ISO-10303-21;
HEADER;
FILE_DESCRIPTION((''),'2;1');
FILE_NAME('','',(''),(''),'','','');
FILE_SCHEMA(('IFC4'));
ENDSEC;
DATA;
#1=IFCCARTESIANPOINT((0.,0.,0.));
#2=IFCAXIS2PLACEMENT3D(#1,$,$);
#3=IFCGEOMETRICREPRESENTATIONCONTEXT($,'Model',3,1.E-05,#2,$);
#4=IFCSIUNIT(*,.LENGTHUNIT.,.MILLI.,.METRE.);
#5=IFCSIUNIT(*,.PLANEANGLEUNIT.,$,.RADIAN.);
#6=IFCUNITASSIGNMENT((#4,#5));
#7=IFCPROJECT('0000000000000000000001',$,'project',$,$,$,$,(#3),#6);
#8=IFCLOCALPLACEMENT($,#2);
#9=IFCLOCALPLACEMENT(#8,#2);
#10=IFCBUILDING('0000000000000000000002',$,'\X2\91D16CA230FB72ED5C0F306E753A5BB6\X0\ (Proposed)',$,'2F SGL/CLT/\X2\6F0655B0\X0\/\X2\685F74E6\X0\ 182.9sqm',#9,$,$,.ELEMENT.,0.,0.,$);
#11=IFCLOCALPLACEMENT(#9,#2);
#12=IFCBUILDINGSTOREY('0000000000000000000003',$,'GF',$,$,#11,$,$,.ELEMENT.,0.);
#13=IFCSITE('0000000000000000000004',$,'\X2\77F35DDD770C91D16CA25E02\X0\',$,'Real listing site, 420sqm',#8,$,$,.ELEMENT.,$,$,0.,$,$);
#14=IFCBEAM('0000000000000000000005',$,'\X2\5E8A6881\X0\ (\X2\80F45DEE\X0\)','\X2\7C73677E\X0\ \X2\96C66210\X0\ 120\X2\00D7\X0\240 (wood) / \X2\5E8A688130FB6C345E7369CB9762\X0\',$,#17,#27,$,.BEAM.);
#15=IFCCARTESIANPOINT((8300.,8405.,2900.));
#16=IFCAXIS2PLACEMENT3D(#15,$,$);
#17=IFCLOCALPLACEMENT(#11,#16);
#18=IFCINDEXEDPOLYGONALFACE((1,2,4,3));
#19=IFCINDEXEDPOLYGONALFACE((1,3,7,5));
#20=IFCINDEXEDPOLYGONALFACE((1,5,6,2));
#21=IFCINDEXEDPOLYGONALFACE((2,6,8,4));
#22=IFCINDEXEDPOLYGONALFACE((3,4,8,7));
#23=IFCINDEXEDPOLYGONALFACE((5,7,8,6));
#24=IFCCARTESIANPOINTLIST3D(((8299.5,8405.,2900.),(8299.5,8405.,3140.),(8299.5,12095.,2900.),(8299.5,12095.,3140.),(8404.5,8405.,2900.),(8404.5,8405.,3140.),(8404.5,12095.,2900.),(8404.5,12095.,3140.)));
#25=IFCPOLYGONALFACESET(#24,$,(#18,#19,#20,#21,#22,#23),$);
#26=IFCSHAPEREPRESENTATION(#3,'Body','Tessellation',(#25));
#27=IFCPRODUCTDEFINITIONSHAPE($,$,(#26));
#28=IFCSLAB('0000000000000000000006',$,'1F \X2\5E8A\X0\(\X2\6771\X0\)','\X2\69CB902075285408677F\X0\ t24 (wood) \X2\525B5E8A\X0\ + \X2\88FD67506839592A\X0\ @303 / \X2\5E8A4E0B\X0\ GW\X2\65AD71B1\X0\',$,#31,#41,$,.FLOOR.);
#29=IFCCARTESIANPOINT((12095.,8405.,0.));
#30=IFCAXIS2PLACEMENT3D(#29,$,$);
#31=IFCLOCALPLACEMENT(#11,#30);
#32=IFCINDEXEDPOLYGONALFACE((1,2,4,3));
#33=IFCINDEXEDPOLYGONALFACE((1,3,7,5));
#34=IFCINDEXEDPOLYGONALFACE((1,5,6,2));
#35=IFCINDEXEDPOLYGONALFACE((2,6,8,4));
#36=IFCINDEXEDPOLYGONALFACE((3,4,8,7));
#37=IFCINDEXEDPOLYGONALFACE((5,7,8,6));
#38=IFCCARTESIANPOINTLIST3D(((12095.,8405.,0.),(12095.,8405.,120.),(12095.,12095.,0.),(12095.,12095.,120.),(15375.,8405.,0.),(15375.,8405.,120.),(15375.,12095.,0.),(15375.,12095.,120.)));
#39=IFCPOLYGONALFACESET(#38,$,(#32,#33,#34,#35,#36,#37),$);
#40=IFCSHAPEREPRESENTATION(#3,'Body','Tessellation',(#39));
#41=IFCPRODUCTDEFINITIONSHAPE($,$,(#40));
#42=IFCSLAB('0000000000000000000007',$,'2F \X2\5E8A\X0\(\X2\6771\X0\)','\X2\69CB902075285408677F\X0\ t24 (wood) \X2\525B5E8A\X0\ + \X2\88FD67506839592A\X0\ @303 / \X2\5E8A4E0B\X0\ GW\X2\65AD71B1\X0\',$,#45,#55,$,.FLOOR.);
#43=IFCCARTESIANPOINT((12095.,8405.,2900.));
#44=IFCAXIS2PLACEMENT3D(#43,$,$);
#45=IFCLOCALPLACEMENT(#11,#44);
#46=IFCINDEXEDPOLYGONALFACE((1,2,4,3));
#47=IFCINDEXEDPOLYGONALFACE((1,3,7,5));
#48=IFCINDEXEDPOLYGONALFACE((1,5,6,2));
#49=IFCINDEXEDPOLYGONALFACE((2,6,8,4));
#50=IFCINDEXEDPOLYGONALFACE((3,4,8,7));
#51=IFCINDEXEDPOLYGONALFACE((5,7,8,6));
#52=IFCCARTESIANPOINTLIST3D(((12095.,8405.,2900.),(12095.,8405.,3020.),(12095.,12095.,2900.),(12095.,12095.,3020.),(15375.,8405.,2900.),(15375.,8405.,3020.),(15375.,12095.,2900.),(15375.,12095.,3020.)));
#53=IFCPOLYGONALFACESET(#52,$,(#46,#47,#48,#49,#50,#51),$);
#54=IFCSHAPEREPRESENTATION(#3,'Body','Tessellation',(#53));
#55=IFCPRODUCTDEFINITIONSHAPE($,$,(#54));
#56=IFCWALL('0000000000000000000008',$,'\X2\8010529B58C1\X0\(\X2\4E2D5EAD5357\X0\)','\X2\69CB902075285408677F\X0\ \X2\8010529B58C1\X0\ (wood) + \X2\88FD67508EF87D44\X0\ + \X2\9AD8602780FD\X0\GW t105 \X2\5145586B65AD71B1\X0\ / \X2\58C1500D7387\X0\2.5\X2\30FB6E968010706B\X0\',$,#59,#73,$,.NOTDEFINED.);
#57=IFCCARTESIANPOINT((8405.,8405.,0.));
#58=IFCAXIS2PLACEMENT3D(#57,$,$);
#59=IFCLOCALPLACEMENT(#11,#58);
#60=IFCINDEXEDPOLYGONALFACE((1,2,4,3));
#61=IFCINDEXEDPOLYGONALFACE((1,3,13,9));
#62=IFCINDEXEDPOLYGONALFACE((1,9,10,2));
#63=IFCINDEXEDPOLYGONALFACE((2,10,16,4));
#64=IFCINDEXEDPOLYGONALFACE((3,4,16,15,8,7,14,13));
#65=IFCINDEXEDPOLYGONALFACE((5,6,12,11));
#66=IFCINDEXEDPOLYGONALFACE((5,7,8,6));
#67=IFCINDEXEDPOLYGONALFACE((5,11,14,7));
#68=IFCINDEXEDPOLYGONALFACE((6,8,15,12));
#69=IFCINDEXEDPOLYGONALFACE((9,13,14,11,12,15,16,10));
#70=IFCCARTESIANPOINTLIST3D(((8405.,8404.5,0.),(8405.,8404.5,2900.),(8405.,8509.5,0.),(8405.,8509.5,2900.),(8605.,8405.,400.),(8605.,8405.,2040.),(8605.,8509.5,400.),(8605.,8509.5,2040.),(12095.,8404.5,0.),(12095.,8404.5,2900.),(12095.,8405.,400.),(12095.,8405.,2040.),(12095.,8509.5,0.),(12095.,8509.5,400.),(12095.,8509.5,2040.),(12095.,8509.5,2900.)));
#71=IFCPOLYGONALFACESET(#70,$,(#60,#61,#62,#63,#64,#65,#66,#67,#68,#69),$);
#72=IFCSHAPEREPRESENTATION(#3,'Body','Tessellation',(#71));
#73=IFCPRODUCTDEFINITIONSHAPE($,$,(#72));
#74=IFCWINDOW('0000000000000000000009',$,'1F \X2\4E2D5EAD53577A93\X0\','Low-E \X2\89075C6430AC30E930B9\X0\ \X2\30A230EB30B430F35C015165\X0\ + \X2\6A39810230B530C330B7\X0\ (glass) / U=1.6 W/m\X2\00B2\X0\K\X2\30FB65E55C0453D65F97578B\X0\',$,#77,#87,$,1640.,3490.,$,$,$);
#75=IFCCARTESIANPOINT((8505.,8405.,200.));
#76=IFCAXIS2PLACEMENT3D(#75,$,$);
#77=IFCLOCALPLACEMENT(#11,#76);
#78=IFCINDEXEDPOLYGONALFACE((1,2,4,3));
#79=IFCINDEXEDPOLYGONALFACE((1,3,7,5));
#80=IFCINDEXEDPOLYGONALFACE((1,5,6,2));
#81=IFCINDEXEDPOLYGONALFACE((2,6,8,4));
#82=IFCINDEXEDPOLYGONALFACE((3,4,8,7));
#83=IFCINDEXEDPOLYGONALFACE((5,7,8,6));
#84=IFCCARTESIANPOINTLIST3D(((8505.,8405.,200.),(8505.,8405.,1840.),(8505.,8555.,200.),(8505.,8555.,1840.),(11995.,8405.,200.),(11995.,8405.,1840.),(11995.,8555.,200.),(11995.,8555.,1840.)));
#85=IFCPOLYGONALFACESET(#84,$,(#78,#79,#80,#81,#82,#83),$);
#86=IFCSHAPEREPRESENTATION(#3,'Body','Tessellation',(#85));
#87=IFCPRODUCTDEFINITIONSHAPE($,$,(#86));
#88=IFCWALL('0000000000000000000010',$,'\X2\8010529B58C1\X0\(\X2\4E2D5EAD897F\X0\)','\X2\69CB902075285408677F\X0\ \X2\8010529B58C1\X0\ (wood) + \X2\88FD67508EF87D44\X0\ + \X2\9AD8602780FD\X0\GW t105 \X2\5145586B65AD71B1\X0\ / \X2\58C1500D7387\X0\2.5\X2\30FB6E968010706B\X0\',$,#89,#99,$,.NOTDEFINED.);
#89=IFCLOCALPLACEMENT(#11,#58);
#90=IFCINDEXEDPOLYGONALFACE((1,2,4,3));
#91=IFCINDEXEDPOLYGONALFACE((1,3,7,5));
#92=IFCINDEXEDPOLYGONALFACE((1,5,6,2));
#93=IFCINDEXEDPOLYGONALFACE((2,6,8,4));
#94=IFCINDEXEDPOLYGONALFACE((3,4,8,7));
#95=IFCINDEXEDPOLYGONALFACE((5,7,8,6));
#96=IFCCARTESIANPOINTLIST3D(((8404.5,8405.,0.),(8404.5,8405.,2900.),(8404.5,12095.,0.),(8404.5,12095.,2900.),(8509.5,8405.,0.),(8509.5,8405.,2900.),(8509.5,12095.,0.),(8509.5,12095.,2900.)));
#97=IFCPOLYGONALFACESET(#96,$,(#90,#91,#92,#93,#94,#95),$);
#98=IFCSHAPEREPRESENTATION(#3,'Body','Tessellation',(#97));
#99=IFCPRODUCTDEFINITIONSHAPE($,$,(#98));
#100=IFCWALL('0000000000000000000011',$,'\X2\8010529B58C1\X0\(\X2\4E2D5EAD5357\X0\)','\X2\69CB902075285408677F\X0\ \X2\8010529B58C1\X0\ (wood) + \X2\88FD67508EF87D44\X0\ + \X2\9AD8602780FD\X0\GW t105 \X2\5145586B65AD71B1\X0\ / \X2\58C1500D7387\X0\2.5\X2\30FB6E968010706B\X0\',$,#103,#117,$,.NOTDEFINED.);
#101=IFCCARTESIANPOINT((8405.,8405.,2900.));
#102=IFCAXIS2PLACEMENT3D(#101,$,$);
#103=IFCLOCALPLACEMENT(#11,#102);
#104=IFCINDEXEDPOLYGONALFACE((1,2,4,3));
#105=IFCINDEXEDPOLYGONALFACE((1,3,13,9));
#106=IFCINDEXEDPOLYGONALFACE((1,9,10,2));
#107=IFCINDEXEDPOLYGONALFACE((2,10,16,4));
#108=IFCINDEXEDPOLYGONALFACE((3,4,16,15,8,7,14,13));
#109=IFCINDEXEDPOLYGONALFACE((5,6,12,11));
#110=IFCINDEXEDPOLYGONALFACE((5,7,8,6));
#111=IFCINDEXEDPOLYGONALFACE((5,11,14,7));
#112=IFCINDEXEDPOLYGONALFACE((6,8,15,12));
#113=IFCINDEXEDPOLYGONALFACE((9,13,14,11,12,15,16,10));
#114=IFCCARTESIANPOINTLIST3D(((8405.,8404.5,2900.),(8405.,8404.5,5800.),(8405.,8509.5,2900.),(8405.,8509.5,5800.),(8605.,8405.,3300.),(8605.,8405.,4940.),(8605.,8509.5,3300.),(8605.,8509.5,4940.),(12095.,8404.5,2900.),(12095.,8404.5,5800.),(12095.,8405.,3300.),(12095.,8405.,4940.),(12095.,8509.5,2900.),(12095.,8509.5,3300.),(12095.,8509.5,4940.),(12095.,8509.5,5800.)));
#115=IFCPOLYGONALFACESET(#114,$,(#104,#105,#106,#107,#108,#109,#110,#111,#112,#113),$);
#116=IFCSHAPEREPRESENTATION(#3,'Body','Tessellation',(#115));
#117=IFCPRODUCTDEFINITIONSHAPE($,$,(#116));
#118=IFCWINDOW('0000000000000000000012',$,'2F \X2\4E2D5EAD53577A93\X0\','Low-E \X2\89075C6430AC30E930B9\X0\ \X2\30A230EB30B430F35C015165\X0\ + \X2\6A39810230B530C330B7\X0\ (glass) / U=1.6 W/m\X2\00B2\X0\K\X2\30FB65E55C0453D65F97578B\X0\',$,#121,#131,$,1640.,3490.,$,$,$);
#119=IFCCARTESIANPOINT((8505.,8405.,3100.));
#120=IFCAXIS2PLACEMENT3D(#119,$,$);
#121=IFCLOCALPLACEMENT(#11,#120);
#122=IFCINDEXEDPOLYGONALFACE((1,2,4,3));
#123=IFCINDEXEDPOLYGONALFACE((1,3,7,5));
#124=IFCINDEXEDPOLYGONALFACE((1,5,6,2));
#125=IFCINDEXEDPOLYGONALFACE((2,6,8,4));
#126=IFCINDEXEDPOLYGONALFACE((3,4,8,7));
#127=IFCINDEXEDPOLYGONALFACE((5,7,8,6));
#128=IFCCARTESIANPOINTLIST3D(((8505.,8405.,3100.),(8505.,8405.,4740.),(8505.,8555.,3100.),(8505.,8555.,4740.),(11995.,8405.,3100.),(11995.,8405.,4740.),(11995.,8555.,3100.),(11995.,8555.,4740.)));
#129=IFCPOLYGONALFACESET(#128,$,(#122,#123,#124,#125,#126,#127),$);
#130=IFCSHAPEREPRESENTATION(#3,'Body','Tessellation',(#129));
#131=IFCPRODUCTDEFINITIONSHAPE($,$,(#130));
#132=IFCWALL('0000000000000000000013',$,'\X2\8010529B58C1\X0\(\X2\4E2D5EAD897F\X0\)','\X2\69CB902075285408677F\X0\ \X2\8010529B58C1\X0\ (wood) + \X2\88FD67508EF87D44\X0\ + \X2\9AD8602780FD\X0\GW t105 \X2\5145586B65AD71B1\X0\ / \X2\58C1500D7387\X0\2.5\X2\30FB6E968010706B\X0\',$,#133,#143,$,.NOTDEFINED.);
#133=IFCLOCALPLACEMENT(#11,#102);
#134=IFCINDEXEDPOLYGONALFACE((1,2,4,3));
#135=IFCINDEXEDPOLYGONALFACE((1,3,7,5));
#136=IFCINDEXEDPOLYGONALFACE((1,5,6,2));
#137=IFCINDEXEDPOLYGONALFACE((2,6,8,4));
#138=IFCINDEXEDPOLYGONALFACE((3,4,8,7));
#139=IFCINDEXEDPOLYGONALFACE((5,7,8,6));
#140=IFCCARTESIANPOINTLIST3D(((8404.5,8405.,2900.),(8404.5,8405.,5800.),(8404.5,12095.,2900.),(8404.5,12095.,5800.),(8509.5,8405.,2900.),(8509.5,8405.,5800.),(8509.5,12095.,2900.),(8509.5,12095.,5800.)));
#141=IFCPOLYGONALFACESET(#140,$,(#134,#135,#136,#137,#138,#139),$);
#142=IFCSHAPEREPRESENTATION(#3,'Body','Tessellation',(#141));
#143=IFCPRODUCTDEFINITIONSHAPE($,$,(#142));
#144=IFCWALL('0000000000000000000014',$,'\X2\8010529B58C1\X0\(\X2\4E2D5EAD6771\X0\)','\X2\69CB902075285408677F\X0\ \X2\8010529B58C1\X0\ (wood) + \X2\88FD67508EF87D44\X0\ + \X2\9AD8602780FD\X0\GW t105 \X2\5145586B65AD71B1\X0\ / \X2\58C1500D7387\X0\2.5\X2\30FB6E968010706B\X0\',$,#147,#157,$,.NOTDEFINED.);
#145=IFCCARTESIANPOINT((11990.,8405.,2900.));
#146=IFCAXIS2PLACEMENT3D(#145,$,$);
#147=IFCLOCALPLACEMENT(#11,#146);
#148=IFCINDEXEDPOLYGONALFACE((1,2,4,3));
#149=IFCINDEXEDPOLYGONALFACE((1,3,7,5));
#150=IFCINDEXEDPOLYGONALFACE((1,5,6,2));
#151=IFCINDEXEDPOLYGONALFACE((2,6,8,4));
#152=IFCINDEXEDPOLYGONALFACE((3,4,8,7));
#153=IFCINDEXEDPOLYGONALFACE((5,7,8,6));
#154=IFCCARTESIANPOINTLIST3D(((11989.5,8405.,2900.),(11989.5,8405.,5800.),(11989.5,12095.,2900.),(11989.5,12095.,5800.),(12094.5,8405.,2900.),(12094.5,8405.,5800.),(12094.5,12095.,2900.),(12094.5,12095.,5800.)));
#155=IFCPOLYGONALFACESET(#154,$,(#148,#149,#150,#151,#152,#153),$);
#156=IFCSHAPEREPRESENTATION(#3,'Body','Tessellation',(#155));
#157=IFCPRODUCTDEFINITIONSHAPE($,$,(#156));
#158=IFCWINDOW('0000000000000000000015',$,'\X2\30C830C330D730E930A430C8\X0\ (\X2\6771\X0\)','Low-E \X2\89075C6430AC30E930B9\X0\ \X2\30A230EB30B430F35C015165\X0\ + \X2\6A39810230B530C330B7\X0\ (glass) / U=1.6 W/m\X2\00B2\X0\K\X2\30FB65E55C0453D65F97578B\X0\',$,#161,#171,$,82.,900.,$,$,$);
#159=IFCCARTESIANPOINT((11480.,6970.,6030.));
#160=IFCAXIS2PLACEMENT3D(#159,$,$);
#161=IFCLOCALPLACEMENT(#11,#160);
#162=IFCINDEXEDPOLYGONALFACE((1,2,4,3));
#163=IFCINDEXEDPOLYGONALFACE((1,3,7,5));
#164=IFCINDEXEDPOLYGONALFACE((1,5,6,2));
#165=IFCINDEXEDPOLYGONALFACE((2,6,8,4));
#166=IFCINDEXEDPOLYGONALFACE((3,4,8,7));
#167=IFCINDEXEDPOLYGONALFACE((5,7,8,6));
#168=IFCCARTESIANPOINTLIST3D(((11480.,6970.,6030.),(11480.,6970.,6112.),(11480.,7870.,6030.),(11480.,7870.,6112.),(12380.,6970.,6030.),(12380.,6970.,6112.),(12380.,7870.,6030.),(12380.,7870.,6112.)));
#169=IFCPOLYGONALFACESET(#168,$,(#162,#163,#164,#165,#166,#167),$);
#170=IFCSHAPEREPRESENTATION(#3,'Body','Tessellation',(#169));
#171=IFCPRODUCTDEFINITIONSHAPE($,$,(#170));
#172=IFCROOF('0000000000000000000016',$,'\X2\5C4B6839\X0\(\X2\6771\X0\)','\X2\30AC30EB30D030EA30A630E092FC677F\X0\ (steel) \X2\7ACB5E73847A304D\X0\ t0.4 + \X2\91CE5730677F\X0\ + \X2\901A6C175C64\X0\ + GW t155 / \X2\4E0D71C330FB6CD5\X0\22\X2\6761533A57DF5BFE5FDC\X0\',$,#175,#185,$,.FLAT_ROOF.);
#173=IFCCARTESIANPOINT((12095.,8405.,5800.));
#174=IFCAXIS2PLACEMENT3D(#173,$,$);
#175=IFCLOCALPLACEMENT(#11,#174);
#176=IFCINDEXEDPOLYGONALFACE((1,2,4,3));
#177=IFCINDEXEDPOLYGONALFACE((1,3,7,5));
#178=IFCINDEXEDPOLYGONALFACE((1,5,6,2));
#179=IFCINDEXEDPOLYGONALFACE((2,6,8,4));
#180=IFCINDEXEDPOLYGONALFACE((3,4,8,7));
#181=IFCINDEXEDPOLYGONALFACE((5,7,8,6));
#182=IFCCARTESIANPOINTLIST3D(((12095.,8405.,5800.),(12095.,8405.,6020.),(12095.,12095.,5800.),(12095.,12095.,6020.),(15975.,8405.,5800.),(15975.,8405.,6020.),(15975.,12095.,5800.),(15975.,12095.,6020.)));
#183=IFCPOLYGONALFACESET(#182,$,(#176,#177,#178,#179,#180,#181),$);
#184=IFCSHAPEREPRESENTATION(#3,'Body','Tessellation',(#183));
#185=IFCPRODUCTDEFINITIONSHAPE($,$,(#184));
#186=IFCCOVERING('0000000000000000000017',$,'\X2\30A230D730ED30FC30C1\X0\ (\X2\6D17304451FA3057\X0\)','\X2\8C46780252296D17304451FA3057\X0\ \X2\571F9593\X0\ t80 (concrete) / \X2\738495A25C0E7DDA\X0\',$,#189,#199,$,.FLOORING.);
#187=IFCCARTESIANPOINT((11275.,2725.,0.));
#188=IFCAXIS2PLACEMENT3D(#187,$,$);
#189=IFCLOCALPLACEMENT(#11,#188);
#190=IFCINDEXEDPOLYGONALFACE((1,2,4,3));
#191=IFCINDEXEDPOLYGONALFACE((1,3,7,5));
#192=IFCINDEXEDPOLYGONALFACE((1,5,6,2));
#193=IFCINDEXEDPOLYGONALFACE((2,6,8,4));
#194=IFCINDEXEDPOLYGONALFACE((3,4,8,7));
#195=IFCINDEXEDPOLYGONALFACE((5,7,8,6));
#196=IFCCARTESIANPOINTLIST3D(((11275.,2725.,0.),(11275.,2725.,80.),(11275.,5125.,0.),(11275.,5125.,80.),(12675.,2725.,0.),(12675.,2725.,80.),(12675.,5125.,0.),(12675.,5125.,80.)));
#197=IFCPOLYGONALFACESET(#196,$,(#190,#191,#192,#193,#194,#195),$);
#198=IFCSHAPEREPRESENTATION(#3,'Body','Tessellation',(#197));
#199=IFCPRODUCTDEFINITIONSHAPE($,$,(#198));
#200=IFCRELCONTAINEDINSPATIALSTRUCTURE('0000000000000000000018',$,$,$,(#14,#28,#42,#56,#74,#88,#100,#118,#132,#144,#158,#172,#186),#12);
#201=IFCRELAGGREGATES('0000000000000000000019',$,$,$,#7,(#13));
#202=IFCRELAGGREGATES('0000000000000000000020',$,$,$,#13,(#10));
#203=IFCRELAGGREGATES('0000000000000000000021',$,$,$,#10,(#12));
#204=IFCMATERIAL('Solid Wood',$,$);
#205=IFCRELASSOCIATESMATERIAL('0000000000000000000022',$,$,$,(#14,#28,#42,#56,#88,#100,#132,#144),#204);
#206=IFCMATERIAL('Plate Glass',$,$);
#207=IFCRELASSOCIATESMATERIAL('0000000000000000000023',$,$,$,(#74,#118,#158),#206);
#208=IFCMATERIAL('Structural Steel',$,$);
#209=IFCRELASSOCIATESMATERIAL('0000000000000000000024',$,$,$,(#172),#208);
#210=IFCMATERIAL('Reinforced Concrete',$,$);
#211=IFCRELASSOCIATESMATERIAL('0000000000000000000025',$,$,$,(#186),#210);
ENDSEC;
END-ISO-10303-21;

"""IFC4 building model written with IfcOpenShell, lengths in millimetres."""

from ifc_helpers import new_model, si_unit, frame, frame_2d, origin, place, context, project, spatial, rectangle, extrude, material, element, fill, save


model = new_model("IFC4")

# Units and contexts
model_context = context("Model", 3, precision=1e-05, world=origin())
ifc_project = project(units=[si_unit("LENGTHUNIT", "METRE", prefix="MILLI"), si_unit("PLANEANGLEUNIT", "RADIAN")], contexts=[model_context])

# Site, building, storey
site_placement = place(None, origin())
site = spatial("IfcSite", under=ifc_project, at=site_placement, Name="石川県金沢市", ObjectType="Real listing site, 420sqm", CompositionType="ELEMENT", RefElevation=0.0)
building_placement = place(site_placement, origin())
building = spatial("IfcBuilding", under=site, at=building_placement, Name="金沢・狭小の町家 (Proposed)", ObjectType="2F SGL/CLT/漆喰/桟瓦 182.9sqm", CompositionType="ELEMENT", ElevationOfRefHeight=0.0, ElevationOfTerrain=0.0)
storey_placement = place(building_placement, origin())
storey = spatial("IfcBuildingStorey", under=building, at=storey_placement, Name="GF", CompositionType="ELEMENT", Elevation=0.0)

# Shared definitions
ifc_material_1 = material(Name="Solid Wood")

# Beam
beam_placement = place(storey_placement, frame((8300.0, 8405.0, 2900.0)))
element("IfcBeam", 1, at=beam_placement, inside=storey, material=ifc_material_1, Name="床梁 (胴差)", Description="米松 集成 120×240 (wood) / 床梁・水平構面", PredefinedType="BEAM", context=model_context, shape_type="SweptSolid", body=[
    extrude(rectangle(XDim=105.0, YDim=3690.0, at=frame_2d((52.0, 1845.0))), frame((8300.0, 8405.0, 2900.0)), (0.0, 0.0, 1.0), 240.0),
])

# Slabs
slab_1_placement = place(storey_placement, frame((12095.0, 8405.0, 0.0)))
element("IfcSlab", 2, at=slab_1_placement, inside=storey, material=ifc_material_1, Name="1F 床(東)", Description="構造用合板 t24 (wood) 剛床 + 製材根太 @303 / 床下 GW断熱", PredefinedType="FLOOR", context=model_context, shape_type="SweptSolid", body=[
    extrude(rectangle(XDim=3280.0, YDim=3690.0, at=frame_2d((1640.0, 1845.0))), frame((12095.0, 8405.0, 0.0)), (0.0, 0.0, 1.0), 120.0),
])
slab_2_placement = place(storey_placement, frame((12095.0, 8405.0, 2900.0)))
element("IfcSlab", 3, at=slab_2_placement, inside=storey, material=ifc_material_1, Name="2F 床(東)", Description="構造用合板 t24 (wood) 剛床 + 製材根太 @303 / 床下 GW断熱", PredefinedType="FLOOR", context=model_context, shape_type="SweptSolid", body=[
    extrude(rectangle(XDim=3280.0, YDim=3690.0, at=frame_2d((1640.0, 1845.0))), frame((12095.0, 8405.0, 2900.0)), (0.0, 0.0, 1.0), 120.0),
])

# Wall, opening, window
wall_1_placement = place(storey_placement, frame((8405.0, 8405.0, 0.0)))
wall_1 = element("IfcWall", 4, at=wall_1_placement, inside=storey, material=ifc_material_1, Name="耐力壁(中庭南)", Description="構造用合板 耐力壁 (wood) + 製材軸組 + 高性能GW t105 充填断熱 / 壁倍率2.5・準耐火", PredefinedType="NOTDEFINED", context=model_context, shape_type="SweptSolid", body=[
    extrude(rectangle(XDim=3690.0, YDim=105.0, at=frame_2d((1845.0, 52.0))), frame((8405.0, 8405.0, 0.0)), (0.0, 0.0, 1.0), 2900.0),
])
opening_1_placement = place(storey_placement, frame((8505.0, 8405.0, 200.0)))
opening_1 = element("IfcOpeningElement", 5, at=opening_1_placement, cuts=wall_1, PredefinedType="NOTDEFINED", context=model_context, shape_type="SweptSolid", body=[
    extrude(rectangle(XDim=3490.0, YDim=150.0, at=frame_2d((1745.0, 75.0))), frame((8505.0, 8405.0, 200.0)), (0.0, 0.0, 1.0), 1640.0),
])
ifc_material_2 = material(Name="Plate Glass")
window_1_placement = place(storey_placement, frame((8505.0, 8405.0, 200.0)))
window_1 = element("IfcWindow", 6, at=window_1_placement, inside=storey, material=ifc_material_2, Name="1F 中庭南窓", Description="Low-E 複層ガラス アルゴン封入 + 樹脂サッシ (glass) / U=1.6 W/m²K・日射取得型", OverallHeight=1640.0, OverallWidth=3490.0, context=model_context, shape_type="SweptSolid", body=[
    extrude(rectangle(XDim=3490.0, YDim=150.0, at=frame_2d((1745.0, 75.0))), frame((8505.0, 8405.0, 200.0)), (0.0, 0.0, 1.0), 1640.0),
])
fill(opening_1, window_1)

# Wall
wall_2_placement = place(storey_placement, frame((8405.0, 8405.0, 0.0)))
element("IfcWall", 7, at=wall_2_placement, inside=storey, material=ifc_material_1, Name="耐力壁(中庭西)", Description="構造用合板 耐力壁 (wood) + 製材軸組 + 高性能GW t105 充填断熱 / 壁倍率2.5・準耐火", PredefinedType="NOTDEFINED", context=model_context, shape_type="SweptSolid", body=[
    extrude(rectangle(XDim=105.0, YDim=3690.0, at=frame_2d((52.0, 1845.0))), frame((8405.0, 8405.0, 0.0)), (0.0, 0.0, 1.0), 2900.0),
])

# Wall, opening, window
wall_3_placement = place(storey_placement, frame((8405.0, 8405.0, 2900.0)))
wall_3 = element("IfcWall", 8, at=wall_3_placement, inside=storey, material=ifc_material_1, Name="耐力壁(中庭南)", Description="構造用合板 耐力壁 (wood) + 製材軸組 + 高性能GW t105 充填断熱 / 壁倍率2.5・準耐火", PredefinedType="NOTDEFINED", context=model_context, shape_type="SweptSolid", body=[
    extrude(rectangle(XDim=3690.0, YDim=105.0, at=frame_2d((1845.0, 52.0))), frame((8405.0, 8405.0, 2900.0)), (0.0, 0.0, 1.0), 2900.0),
])
opening_2_placement = place(storey_placement, frame((8505.0, 8405.0, 3100.0)))
opening_2 = element("IfcOpeningElement", 9, at=opening_2_placement, cuts=wall_3, PredefinedType="NOTDEFINED", context=model_context, shape_type="SweptSolid", body=[
    extrude(rectangle(XDim=3490.0, YDim=150.0, at=frame_2d((1745.0, 75.0))), frame((8505.0, 8405.0, 3100.0)), (0.0, 0.0, 1.0), 1640.0),
])
window_2_placement = place(storey_placement, frame((8505.0, 8405.0, 3100.0)))
window_2 = element("IfcWindow", 10, at=window_2_placement, inside=storey, material=ifc_material_2, Name="2F 中庭南窓", Description="Low-E 複層ガラス アルゴン封入 + 樹脂サッシ (glass) / U=1.6 W/m²K・日射取得型", OverallHeight=1640.0, OverallWidth=3490.0, context=model_context, shape_type="SweptSolid", body=[
    extrude(rectangle(XDim=3490.0, YDim=150.0, at=frame_2d((1745.0, 75.0))), frame((8505.0, 8405.0, 3100.0)), (0.0, 0.0, 1.0), 1640.0),
])
fill(opening_2, window_2)

# Walls
wall_4_placement = place(storey_placement, frame((8405.0, 8405.0, 2900.0)))
element("IfcWall", 11, at=wall_4_placement, inside=storey, material=ifc_material_1, Name="耐力壁(中庭西)", Description="構造用合板 耐力壁 (wood) + 製材軸組 + 高性能GW t105 充填断熱 / 壁倍率2.5・準耐火", PredefinedType="NOTDEFINED", context=model_context, shape_type="SweptSolid", body=[
    extrude(rectangle(XDim=105.0, YDim=3690.0, at=frame_2d((52.0, 1845.0))), frame((8405.0, 8405.0, 2900.0)), (0.0, 0.0, 1.0), 2900.0),
])
wall_5_placement = place(storey_placement, frame((11990.0, 8405.0, 2900.0)))
element("IfcWall", 12, at=wall_5_placement, inside=storey, material=ifc_material_1, Name="耐力壁(中庭東)", Description="構造用合板 耐力壁 (wood) + 製材軸組 + 高性能GW t105 充填断熱 / 壁倍率2.5・準耐火", PredefinedType="NOTDEFINED", context=model_context, shape_type="SweptSolid", body=[
    extrude(rectangle(XDim=105.0, YDim=3690.0, at=frame_2d((52.0, 1845.0))), frame((11990.0, 8405.0, 2900.0)), (0.0, 0.0, 1.0), 2900.0),
])

# Window
window_3_placement = place(storey_placement, frame((11480.0, 6970.0, 6030.0)))
element("IfcWindow", 13, at=window_3_placement, inside=storey, material=ifc_material_2, Name="トップライト (東)", Description="Low-E 複層ガラス アルゴン封入 + 樹脂サッシ (glass) / U=1.6 W/m²K・日射取得型", OverallHeight=82.0, OverallWidth=900.0, context=model_context, shape_type="SweptSolid", body=[
    extrude(rectangle(XDim=900.0, YDim=900.0, at=frame_2d((450.0, 450.0))), frame((11480.0, 6970.0, 6030.0)), (0.0, 0.0, 1.0), 82.0),
])

# Roof
ifc_material_3 = material(Name="Structural Steel")
roof_placement = place(storey_placement, frame((12095.0, 8405.0, 5800.0)))
element("IfcRoof", 14, at=roof_placement, inside=storey, material=ifc_material_3, Name="屋根(東)", Description="ガルバリウム鋼板 (steel) 立平葺き t0.4 + 野地板 + 通気層 + GW t155 / 不燃・法22条区域対応", PredefinedType="FLAT_ROOF", context=model_context, shape_type="SweptSolid", body=[
    extrude(rectangle(XDim=3880.0, YDim=3690.0, at=frame_2d((1940.0, 1845.0))), frame((12095.0, 8405.0, 5800.0)), (0.0, 0.0, 1.0), 220.0),
])

# Covering
ifc_material_4 = material(Name="Reinforced Concrete")
covering_placement = place(storey_placement, frame((11275.0, 2725.0, 0.0)))
element("IfcCovering", 15, at=covering_placement, inside=storey, material=ifc_material_4, Name="アプローチ (洗い出し)", Description="豆砂利洗い出し 土間 t80 (concrete) / 玄関導線", PredefinedType="FLOORING", context=model_context, shape_type="SweptSolid", body=[
    extrude(rectangle(XDim=1400.0, YDim=2400.0, at=frame_2d((700.0, 1200.0))), frame((11275.0, 2725.0, 0.0)), (0.0, 0.0, 1.0), 80.0),
])

save(model, "model.ifc")
